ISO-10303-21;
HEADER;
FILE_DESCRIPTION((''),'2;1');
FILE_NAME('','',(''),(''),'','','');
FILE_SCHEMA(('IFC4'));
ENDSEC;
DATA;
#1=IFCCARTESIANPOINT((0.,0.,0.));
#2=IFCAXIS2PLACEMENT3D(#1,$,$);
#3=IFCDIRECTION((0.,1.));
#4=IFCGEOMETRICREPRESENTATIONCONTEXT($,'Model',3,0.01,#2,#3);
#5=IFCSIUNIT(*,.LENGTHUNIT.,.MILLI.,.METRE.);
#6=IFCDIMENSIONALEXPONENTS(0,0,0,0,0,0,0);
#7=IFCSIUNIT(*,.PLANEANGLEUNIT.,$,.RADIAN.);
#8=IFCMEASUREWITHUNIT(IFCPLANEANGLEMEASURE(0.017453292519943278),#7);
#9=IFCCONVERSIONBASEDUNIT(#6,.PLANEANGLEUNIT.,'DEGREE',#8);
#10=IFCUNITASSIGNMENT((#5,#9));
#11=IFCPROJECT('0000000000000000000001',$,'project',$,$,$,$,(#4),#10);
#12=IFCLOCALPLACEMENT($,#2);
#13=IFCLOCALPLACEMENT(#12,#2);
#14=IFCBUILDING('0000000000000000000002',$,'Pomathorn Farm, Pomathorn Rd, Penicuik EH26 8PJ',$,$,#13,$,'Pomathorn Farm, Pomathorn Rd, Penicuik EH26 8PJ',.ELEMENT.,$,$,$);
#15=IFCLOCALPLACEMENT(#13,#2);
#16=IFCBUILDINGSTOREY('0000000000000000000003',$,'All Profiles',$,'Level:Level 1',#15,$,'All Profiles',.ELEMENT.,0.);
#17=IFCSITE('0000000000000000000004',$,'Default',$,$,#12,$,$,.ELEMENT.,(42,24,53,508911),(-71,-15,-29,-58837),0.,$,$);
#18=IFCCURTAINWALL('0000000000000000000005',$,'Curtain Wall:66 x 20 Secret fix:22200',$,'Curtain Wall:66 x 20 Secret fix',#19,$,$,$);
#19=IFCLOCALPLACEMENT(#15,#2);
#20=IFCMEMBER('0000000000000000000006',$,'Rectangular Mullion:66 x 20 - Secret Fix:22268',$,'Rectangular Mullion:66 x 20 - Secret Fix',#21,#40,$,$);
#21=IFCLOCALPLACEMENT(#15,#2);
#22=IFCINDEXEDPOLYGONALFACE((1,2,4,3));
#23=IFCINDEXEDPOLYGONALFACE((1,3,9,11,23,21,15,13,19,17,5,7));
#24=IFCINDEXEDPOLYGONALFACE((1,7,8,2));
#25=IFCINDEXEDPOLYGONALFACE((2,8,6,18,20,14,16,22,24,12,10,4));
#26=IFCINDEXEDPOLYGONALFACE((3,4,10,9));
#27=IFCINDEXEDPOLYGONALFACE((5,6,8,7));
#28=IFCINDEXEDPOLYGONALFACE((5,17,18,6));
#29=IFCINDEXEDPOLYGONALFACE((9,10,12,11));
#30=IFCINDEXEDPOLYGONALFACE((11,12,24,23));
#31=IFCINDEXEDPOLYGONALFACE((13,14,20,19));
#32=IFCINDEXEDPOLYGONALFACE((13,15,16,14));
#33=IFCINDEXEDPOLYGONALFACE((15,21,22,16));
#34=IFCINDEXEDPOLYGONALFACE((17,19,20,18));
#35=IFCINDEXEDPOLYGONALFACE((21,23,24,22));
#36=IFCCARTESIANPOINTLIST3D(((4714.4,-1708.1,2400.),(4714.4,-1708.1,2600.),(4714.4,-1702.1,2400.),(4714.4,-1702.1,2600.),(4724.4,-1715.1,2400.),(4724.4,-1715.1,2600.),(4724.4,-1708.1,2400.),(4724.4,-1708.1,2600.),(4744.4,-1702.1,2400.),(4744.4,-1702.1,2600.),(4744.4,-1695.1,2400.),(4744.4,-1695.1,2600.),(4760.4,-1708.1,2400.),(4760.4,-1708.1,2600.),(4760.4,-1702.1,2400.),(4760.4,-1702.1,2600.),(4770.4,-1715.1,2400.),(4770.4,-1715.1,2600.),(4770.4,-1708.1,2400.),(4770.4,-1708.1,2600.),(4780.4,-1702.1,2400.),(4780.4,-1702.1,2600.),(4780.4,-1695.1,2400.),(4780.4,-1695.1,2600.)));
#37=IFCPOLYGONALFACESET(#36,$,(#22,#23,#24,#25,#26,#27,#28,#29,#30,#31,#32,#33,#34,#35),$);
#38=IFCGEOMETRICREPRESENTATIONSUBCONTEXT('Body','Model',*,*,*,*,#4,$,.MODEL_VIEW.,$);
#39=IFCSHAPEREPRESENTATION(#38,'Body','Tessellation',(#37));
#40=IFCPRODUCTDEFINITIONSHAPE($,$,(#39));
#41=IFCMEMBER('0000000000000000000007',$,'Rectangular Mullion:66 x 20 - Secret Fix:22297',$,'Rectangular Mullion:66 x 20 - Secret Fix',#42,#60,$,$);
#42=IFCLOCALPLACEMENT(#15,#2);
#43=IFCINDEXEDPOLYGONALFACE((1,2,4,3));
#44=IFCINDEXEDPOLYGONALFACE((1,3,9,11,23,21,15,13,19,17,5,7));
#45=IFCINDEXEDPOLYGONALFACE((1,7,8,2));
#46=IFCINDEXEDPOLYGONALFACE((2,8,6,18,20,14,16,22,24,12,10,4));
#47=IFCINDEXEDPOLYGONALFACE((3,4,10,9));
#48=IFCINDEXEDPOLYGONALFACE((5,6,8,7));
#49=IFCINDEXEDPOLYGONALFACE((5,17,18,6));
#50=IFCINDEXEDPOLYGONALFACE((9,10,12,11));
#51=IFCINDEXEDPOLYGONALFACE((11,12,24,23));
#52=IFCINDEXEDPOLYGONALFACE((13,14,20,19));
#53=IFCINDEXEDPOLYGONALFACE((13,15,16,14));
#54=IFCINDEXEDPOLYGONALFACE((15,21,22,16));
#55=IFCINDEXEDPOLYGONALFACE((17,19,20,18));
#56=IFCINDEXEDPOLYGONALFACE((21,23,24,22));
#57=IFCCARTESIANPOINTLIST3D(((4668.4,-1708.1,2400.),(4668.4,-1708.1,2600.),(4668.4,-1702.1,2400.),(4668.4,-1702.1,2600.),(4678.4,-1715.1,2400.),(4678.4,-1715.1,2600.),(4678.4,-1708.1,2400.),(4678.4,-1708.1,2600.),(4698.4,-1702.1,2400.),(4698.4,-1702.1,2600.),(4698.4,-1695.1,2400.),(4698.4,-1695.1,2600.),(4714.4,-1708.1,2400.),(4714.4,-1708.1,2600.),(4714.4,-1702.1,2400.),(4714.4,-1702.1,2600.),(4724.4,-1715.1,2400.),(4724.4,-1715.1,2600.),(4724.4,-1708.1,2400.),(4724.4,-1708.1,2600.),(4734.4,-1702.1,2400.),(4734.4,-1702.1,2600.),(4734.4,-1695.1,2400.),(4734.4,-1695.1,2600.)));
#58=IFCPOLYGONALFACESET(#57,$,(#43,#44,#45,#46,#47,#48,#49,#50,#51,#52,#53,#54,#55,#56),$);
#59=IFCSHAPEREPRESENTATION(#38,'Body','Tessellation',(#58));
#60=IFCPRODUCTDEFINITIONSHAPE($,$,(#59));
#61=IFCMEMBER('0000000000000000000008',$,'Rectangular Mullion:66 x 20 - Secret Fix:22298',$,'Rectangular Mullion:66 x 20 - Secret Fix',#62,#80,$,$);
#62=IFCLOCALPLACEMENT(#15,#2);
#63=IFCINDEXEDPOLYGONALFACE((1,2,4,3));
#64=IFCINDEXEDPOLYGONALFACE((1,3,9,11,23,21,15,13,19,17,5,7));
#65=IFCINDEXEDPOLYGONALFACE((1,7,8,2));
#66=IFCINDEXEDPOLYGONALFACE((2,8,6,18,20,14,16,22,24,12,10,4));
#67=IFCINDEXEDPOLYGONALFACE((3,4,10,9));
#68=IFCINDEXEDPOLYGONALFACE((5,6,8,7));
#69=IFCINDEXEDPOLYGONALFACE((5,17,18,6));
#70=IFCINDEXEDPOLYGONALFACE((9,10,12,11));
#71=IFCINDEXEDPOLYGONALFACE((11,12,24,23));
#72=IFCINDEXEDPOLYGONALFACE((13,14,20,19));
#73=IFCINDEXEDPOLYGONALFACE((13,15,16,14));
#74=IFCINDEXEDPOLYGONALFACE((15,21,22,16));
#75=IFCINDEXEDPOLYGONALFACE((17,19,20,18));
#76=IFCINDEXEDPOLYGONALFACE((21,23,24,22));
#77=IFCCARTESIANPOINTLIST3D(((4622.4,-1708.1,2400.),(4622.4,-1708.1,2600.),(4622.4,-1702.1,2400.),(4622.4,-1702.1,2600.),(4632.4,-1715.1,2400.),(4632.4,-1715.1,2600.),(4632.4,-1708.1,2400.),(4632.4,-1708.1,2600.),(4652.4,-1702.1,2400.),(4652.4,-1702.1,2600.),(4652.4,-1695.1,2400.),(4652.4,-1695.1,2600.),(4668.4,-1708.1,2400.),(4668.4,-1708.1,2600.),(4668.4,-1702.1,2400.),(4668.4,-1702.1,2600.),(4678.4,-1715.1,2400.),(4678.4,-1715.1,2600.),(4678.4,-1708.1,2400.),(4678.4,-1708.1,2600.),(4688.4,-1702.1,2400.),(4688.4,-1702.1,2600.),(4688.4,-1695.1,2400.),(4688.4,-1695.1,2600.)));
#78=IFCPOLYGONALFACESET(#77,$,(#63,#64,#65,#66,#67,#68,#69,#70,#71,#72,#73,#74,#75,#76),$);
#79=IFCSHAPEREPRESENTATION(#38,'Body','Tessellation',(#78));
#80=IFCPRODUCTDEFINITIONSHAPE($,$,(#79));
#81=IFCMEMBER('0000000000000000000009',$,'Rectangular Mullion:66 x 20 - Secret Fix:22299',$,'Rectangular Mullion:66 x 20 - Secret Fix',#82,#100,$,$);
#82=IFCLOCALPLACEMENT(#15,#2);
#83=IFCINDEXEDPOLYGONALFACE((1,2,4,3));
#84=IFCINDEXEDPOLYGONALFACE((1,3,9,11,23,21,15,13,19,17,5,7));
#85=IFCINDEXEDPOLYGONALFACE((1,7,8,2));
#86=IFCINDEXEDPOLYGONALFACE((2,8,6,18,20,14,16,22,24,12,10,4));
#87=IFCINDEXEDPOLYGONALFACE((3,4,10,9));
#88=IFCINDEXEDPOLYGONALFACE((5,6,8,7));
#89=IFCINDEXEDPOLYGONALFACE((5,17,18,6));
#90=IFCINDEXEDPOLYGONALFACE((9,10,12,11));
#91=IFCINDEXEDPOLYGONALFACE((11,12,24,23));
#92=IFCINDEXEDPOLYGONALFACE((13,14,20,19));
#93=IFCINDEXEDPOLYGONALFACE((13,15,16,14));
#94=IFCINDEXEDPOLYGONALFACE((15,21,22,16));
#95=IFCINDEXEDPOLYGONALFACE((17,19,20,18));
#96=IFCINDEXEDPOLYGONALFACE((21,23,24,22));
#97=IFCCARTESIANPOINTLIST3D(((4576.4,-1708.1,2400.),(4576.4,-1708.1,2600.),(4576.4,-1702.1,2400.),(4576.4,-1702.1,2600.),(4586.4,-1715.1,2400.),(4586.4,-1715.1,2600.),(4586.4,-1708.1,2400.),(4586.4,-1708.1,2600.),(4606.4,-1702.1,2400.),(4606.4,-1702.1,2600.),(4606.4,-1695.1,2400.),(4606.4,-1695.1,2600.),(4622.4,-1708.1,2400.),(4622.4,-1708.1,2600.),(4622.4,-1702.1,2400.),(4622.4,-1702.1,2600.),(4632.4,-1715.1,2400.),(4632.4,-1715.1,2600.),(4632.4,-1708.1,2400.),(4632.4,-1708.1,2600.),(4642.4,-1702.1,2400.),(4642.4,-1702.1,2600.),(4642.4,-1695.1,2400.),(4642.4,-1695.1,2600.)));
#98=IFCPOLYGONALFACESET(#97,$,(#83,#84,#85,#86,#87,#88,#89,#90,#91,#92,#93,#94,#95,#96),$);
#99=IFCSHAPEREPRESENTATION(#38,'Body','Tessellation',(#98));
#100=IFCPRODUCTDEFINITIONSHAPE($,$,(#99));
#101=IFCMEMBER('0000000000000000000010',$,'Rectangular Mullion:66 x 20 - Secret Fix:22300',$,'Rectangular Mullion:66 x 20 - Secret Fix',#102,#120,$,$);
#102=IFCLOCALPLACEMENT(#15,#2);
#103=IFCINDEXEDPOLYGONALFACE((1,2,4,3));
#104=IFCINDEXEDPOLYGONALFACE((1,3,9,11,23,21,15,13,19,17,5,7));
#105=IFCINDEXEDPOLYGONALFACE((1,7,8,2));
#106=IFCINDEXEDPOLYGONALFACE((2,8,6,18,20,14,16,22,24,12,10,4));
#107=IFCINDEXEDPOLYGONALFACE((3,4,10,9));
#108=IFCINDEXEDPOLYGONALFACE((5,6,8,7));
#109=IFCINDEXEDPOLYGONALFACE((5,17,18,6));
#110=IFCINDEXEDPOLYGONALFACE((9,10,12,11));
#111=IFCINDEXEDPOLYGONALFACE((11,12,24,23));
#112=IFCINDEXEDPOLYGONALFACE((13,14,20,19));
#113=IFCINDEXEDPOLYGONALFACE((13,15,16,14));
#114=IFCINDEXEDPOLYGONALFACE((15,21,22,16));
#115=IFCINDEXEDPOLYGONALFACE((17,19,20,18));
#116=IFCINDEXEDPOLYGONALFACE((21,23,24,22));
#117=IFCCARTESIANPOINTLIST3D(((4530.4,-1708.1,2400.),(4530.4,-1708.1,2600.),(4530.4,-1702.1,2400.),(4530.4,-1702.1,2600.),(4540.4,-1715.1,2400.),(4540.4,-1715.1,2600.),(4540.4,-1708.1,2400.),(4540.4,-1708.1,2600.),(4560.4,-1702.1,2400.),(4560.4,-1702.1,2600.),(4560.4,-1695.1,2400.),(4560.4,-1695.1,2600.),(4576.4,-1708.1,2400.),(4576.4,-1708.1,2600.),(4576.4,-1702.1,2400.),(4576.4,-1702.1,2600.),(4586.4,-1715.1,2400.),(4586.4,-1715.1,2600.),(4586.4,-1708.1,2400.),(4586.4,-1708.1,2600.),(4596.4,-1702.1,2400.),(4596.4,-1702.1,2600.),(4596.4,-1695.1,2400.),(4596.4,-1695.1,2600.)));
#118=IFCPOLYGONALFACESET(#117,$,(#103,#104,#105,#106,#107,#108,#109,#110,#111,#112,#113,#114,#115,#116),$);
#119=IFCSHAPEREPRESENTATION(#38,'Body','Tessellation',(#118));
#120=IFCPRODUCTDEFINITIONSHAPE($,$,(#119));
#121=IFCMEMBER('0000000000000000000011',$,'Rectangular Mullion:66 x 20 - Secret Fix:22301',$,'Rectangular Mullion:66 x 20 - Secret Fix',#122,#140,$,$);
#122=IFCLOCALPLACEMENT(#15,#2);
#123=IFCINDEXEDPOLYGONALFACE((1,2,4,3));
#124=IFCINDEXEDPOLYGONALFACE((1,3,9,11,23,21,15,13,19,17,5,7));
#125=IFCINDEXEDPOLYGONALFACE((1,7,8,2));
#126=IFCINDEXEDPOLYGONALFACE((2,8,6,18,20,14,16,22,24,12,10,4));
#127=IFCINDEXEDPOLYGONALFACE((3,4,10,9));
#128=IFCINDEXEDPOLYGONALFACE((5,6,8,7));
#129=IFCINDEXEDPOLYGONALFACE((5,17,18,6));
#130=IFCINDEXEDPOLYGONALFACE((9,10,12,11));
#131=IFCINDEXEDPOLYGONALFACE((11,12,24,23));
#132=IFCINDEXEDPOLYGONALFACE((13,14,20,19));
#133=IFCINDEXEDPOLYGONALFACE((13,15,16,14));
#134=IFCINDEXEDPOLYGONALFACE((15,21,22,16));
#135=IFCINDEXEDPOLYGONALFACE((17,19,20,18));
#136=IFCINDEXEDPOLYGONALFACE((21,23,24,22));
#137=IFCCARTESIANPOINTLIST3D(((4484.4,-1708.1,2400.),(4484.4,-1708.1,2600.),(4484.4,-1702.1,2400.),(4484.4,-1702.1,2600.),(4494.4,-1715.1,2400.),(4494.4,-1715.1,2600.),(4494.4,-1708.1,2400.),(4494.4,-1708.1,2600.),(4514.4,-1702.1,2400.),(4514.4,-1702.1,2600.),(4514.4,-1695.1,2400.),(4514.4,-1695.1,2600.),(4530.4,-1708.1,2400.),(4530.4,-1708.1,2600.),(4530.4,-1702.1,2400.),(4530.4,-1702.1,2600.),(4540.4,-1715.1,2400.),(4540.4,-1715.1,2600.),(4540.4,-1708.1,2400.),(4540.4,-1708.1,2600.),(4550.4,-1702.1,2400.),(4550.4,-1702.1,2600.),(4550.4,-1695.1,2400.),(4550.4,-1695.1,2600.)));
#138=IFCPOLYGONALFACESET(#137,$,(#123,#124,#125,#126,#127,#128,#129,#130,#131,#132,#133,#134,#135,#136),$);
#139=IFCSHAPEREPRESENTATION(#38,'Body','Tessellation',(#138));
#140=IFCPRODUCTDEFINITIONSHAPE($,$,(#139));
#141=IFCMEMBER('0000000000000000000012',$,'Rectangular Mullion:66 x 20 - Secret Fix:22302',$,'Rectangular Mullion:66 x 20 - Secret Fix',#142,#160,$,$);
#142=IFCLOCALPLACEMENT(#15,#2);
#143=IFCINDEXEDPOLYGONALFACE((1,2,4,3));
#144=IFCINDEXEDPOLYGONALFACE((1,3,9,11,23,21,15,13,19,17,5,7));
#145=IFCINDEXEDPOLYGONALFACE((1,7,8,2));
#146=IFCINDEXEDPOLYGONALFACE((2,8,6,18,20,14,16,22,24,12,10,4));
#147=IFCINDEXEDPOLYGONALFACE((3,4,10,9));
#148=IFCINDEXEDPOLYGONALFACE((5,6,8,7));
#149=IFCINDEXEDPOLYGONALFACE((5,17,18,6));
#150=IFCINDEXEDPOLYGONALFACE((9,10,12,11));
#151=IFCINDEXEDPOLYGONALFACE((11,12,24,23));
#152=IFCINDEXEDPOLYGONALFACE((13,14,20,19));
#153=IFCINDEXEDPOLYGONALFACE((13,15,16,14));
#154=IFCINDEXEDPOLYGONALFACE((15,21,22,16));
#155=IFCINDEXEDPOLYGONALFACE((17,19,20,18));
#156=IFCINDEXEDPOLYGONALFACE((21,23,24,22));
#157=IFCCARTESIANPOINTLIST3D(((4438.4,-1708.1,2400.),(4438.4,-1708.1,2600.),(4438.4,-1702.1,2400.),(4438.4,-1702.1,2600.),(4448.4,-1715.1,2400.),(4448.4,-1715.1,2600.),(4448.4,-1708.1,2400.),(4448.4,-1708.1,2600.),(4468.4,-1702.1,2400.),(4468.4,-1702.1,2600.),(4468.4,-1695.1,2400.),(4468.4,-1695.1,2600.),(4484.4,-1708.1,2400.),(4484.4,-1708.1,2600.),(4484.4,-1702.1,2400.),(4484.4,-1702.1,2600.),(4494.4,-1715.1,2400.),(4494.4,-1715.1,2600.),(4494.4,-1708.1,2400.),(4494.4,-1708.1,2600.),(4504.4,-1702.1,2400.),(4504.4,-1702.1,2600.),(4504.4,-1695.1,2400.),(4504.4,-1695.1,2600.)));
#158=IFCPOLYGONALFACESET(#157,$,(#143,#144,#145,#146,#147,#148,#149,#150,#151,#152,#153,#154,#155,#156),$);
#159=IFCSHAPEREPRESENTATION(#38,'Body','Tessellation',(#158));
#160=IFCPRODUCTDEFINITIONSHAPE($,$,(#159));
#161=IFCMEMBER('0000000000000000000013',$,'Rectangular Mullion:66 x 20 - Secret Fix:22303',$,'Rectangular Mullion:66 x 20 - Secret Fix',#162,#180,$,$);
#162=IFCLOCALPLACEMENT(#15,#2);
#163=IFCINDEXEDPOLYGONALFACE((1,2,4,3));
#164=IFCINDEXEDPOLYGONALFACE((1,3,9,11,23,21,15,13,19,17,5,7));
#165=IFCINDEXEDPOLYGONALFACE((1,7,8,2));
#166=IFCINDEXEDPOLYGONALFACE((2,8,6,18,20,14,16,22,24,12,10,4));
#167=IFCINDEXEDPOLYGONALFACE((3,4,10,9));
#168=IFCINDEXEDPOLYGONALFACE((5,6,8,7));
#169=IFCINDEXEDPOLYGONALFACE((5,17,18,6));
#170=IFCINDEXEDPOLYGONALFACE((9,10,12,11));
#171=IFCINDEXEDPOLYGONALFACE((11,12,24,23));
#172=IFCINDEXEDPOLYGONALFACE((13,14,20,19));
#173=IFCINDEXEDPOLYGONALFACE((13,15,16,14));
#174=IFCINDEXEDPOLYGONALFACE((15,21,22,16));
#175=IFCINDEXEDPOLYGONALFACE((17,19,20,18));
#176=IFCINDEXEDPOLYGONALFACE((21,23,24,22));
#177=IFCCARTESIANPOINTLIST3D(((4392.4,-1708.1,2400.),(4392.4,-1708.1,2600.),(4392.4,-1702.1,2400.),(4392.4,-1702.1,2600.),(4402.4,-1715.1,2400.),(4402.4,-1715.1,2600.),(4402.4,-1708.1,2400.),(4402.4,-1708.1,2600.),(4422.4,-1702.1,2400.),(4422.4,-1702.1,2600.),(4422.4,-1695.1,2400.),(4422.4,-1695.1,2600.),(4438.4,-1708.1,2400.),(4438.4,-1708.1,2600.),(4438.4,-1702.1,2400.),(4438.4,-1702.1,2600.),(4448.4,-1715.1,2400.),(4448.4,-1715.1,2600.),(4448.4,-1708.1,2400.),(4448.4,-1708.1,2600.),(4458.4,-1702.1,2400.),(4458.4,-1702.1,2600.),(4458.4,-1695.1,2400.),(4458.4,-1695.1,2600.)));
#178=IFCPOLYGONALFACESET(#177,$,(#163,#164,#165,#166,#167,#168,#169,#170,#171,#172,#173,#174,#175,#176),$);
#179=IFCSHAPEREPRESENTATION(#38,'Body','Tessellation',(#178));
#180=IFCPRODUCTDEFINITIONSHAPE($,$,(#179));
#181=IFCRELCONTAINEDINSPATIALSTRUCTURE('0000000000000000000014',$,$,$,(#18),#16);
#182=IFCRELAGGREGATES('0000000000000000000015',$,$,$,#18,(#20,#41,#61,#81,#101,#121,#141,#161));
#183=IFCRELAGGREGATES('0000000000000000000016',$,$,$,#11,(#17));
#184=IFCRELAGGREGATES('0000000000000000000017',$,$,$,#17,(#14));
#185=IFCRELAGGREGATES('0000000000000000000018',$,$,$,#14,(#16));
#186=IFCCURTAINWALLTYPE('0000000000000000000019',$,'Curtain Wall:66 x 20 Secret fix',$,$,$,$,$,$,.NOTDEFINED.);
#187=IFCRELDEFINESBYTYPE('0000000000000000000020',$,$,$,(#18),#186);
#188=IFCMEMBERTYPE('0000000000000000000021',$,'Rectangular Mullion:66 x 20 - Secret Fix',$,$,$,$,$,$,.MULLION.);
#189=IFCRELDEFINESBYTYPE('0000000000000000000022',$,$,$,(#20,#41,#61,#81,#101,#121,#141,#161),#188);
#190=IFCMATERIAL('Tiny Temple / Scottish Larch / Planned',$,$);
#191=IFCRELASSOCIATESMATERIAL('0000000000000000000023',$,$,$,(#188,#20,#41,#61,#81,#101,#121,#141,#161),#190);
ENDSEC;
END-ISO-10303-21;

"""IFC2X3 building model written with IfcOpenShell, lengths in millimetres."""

from ifc_helpers import new_model, entity, si_unit, converted_unit, direction, frame, origin, place, context, subcontext, project, spatial, polyline, outline, extrude, source, transform, mapped, material, type_object, type_shapes, element, aggregate, save


model = new_model("IFC2X3")

# Units and contexts
model_context = context("Model", 3, precision=0.01, world=origin(), true_north=direction((0.0, 1.0)))
body_context = subcontext(model_context, "Body", "Model", "MODEL_VIEW")
ifc_project = project(units=[si_unit("LENGTHUNIT", "METRE", prefix="MILLI"), converted_unit("PLANEANGLEUNIT", "DEGREE", entity("IfcPlaneAngleMeasure", 0.017453292519943278), si_unit("PLANEANGLEUNIT", "RADIAN"), dimensions=[0, 0, 0, 0, 0, 0, 0])], contexts=[model_context])

# Site, building, storey
site_placement = place(None, origin())
site = spatial("IfcSite", under=ifc_project, at=site_placement, Name="Default", CompositionType="ELEMENT", RefLatitude=(42, 24, 53, 508911), RefLongitude=(-71, -15, -29, -58837), RefElevation=0.0)
building_placement = place(site_placement, origin())
building = spatial("IfcBuilding", under=site, at=building_placement, Name="Pomathorn Farm, Pomathorn Rd, Penicuik EH26 8PJ", LongName="Pomathorn Farm, Pomathorn Rd, Penicuik EH26 8PJ", CompositionType="ELEMENT")
storey_placement = place(building_placement, origin())
storey = spatial("IfcBuildingStorey", under=building, at=storey_placement, Name="All Profiles", ObjectType="Level:Level 1", LongName="All Profiles", CompositionType="ELEMENT", Elevation=0.0)

# Curtain wall, members
curtain_wall_type = type_object("IfcCurtainWallType", Name="Curtain Wall:66 x 20 Secret fix", PredefinedType="NOTDEFINED")
curtain_wall_placement = place(storey_placement, origin())
curtain_wall = element("IfcCurtainWall", 1, at=curtain_wall_placement, inside=storey, type_object=curtain_wall_type, Name="Curtain Wall:66 x 20 Secret fix:22200", ObjectType="Curtain Wall:66 x 20 Secret fix")
ifc_material = material(Name="Tiny Temple / Scottish Larch / Planned")
member_type_1 = type_object("IfcMemberType", Name="Rectangular Mullion:66 x 20 - Secret Fix", PredefinedType="MULLION", material=ifc_material)
shared_shape_1 = source(origin(), body_context, "Body", "SweptSolid", [
    extrude(outline(polyline([(-3.0, -34.7), (3.0, -34.7), (3.0, -4.7), (10.0, -4.7), (10.0, 31.3), (3.0, 31.3), (3.0, 11.3), (-3.0, 11.3), (-3.0, 21.3), (-10.0, 21.3), (-10.0, -24.7), (-3.0, -24.7), (-3.0, -34.7)])), frame((-31.3, -10.0, -200.0), z_axis=(0.0, 0.0, 1.0), x_axis=(0.0, -1.0, 0.0)), (0.0, 0.0, 1.0), 200.0),
])
type_shapes(member_type_1, [shared_shape_1])
member_1_placement = place(curtain_wall_placement, frame((4780.4, -1715.1, 2400.0), z_axis=(0.0, 0.0, -1.0), x_axis=(1.0, 0.0, 0.0)))
member_1 = element("IfcMember", 2, at=member_1_placement, type_object=member_type_1, material=ifc_material, Name="Rectangular Mullion:66 x 20 - Secret Fix:22268", ObjectType="Rectangular Mullion:66 x 20 - Secret Fix", context=body_context, shape_type="MappedRepresentation", body=[
    mapped(shared_shape_1, transform((0.0, 0.0, 0.0), scale=1.0)),
])
member_2_placement = place(curtain_wall_placement, frame((4734.4, -1715.1, 2400.0), z_axis=(0.0, 0.0, -1.0), x_axis=(1.0, 0.0, 0.0)))
member_2 = element("IfcMember", 3, at=member_2_placement, type_object=member_type_1, material=ifc_material, Name="Rectangular Mullion:66 x 20 - Secret Fix:22297", ObjectType="Rectangular Mullion:66 x 20 - Secret Fix", context=body_context, shape_type="MappedRepresentation", body=[
    mapped(shared_shape_1, transform((0.0, 0.0, 0.0), scale=1.0)),
])
member_3_placement = place(curtain_wall_placement, frame((4688.4, -1715.1, 2400.0), z_axis=(0.0, 0.0, -1.0), x_axis=(1.0, 0.0, 0.0)))
member_3 = element("IfcMember", 4, at=member_3_placement, type_object=member_type_1, material=ifc_material, Name="Rectangular Mullion:66 x 20 - Secret Fix:22298", ObjectType="Rectangular Mullion:66 x 20 - Secret Fix", context=body_context, shape_type="MappedRepresentation", body=[
    mapped(shared_shape_1, transform((0.0, 0.0, 0.0), scale=1.0)),
])
member_4_placement = place(curtain_wall_placement, frame((4642.4, -1715.1, 2400.0), z_axis=(0.0, 0.0, -1.0), x_axis=(1.0, 0.0, 0.0)))
member_4 = element("IfcMember", 5, at=member_4_placement, type_object=member_type_1, material=ifc_material, Name="Rectangular Mullion:66 x 20 - Secret Fix:22299", ObjectType="Rectangular Mullion:66 x 20 - Secret Fix", context=body_context, shape_type="MappedRepresentation", body=[
    mapped(shared_shape_1, transform((0.0, 0.0, 0.0), scale=1.0)),
])
member_5_placement = place(curtain_wall_placement, frame((4596.4, -1715.1, 2400.0), z_axis=(0.0, 0.0, -1.0), x_axis=(1.0, 0.0, 0.0)))
member_5 = element("IfcMember", 6, at=member_5_placement, type_object=member_type_1, material=ifc_material, Name="Rectangular Mullion:66 x 20 - Secret Fix:22300", ObjectType="Rectangular Mullion:66 x 20 - Secret Fix", context=body_context, shape_type="MappedRepresentation", body=[
    mapped(shared_shape_1, transform((0.0, 0.0, 0.0), scale=1.0)),
])
member_6_placement = place(curtain_wall_placement, frame((4550.4, -1715.1, 2400.0), z_axis=(0.0, 0.0, -1.0), x_axis=(1.0, 0.0, 0.0)))
member_6 = element("IfcMember", 7, at=member_6_placement, type_object=member_type_1, material=ifc_material, Name="Rectangular Mullion:66 x 20 - Secret Fix:22301", ObjectType="Rectangular Mullion:66 x 20 - Secret Fix", context=body_context, shape_type="MappedRepresentation", body=[
    mapped(shared_shape_1, transform((0.0, 0.0, 0.0), scale=1.0)),
])
member_7_placement = place(curtain_wall_placement, frame((4504.4, -1715.1, 2400.0), z_axis=(0.0, 0.0, -1.0), x_axis=(1.0, 0.0, 0.0)))
member_7 = element("IfcMember", 8, at=member_7_placement, type_object=member_type_1, material=ifc_material, Name="Rectangular Mullion:66 x 20 - Secret Fix:22302", ObjectType="Rectangular Mullion:66 x 20 - Secret Fix", context=body_context, shape_type="MappedRepresentation", body=[
    mapped(shared_shape_1, transform((0.0, 0.0, 0.0), scale=1.0)),
])
member_8_placement = place(curtain_wall_placement, frame((4458.4, -1715.1, 2400.0), z_axis=(0.0, 0.0, -1.0), x_axis=(1.0, 0.0, 0.0)))
member_8 = element("IfcMember", 9, at=member_8_placement, type_object=member_type_1, material=ifc_material, Name="Rectangular Mullion:66 x 20 - Secret Fix:22303", ObjectType="Rectangular Mullion:66 x 20 - Secret Fix", context=body_context, shape_type="MappedRepresentation", body=[
    mapped(shared_shape_1, transform((0.0, 0.0, 0.0), scale=1.0)),
])
aggregate(curtain_wall, [member_1, member_2, member_3, member_4, member_5, member_6, member_7, member_8])

save(model, "model.ifc")
